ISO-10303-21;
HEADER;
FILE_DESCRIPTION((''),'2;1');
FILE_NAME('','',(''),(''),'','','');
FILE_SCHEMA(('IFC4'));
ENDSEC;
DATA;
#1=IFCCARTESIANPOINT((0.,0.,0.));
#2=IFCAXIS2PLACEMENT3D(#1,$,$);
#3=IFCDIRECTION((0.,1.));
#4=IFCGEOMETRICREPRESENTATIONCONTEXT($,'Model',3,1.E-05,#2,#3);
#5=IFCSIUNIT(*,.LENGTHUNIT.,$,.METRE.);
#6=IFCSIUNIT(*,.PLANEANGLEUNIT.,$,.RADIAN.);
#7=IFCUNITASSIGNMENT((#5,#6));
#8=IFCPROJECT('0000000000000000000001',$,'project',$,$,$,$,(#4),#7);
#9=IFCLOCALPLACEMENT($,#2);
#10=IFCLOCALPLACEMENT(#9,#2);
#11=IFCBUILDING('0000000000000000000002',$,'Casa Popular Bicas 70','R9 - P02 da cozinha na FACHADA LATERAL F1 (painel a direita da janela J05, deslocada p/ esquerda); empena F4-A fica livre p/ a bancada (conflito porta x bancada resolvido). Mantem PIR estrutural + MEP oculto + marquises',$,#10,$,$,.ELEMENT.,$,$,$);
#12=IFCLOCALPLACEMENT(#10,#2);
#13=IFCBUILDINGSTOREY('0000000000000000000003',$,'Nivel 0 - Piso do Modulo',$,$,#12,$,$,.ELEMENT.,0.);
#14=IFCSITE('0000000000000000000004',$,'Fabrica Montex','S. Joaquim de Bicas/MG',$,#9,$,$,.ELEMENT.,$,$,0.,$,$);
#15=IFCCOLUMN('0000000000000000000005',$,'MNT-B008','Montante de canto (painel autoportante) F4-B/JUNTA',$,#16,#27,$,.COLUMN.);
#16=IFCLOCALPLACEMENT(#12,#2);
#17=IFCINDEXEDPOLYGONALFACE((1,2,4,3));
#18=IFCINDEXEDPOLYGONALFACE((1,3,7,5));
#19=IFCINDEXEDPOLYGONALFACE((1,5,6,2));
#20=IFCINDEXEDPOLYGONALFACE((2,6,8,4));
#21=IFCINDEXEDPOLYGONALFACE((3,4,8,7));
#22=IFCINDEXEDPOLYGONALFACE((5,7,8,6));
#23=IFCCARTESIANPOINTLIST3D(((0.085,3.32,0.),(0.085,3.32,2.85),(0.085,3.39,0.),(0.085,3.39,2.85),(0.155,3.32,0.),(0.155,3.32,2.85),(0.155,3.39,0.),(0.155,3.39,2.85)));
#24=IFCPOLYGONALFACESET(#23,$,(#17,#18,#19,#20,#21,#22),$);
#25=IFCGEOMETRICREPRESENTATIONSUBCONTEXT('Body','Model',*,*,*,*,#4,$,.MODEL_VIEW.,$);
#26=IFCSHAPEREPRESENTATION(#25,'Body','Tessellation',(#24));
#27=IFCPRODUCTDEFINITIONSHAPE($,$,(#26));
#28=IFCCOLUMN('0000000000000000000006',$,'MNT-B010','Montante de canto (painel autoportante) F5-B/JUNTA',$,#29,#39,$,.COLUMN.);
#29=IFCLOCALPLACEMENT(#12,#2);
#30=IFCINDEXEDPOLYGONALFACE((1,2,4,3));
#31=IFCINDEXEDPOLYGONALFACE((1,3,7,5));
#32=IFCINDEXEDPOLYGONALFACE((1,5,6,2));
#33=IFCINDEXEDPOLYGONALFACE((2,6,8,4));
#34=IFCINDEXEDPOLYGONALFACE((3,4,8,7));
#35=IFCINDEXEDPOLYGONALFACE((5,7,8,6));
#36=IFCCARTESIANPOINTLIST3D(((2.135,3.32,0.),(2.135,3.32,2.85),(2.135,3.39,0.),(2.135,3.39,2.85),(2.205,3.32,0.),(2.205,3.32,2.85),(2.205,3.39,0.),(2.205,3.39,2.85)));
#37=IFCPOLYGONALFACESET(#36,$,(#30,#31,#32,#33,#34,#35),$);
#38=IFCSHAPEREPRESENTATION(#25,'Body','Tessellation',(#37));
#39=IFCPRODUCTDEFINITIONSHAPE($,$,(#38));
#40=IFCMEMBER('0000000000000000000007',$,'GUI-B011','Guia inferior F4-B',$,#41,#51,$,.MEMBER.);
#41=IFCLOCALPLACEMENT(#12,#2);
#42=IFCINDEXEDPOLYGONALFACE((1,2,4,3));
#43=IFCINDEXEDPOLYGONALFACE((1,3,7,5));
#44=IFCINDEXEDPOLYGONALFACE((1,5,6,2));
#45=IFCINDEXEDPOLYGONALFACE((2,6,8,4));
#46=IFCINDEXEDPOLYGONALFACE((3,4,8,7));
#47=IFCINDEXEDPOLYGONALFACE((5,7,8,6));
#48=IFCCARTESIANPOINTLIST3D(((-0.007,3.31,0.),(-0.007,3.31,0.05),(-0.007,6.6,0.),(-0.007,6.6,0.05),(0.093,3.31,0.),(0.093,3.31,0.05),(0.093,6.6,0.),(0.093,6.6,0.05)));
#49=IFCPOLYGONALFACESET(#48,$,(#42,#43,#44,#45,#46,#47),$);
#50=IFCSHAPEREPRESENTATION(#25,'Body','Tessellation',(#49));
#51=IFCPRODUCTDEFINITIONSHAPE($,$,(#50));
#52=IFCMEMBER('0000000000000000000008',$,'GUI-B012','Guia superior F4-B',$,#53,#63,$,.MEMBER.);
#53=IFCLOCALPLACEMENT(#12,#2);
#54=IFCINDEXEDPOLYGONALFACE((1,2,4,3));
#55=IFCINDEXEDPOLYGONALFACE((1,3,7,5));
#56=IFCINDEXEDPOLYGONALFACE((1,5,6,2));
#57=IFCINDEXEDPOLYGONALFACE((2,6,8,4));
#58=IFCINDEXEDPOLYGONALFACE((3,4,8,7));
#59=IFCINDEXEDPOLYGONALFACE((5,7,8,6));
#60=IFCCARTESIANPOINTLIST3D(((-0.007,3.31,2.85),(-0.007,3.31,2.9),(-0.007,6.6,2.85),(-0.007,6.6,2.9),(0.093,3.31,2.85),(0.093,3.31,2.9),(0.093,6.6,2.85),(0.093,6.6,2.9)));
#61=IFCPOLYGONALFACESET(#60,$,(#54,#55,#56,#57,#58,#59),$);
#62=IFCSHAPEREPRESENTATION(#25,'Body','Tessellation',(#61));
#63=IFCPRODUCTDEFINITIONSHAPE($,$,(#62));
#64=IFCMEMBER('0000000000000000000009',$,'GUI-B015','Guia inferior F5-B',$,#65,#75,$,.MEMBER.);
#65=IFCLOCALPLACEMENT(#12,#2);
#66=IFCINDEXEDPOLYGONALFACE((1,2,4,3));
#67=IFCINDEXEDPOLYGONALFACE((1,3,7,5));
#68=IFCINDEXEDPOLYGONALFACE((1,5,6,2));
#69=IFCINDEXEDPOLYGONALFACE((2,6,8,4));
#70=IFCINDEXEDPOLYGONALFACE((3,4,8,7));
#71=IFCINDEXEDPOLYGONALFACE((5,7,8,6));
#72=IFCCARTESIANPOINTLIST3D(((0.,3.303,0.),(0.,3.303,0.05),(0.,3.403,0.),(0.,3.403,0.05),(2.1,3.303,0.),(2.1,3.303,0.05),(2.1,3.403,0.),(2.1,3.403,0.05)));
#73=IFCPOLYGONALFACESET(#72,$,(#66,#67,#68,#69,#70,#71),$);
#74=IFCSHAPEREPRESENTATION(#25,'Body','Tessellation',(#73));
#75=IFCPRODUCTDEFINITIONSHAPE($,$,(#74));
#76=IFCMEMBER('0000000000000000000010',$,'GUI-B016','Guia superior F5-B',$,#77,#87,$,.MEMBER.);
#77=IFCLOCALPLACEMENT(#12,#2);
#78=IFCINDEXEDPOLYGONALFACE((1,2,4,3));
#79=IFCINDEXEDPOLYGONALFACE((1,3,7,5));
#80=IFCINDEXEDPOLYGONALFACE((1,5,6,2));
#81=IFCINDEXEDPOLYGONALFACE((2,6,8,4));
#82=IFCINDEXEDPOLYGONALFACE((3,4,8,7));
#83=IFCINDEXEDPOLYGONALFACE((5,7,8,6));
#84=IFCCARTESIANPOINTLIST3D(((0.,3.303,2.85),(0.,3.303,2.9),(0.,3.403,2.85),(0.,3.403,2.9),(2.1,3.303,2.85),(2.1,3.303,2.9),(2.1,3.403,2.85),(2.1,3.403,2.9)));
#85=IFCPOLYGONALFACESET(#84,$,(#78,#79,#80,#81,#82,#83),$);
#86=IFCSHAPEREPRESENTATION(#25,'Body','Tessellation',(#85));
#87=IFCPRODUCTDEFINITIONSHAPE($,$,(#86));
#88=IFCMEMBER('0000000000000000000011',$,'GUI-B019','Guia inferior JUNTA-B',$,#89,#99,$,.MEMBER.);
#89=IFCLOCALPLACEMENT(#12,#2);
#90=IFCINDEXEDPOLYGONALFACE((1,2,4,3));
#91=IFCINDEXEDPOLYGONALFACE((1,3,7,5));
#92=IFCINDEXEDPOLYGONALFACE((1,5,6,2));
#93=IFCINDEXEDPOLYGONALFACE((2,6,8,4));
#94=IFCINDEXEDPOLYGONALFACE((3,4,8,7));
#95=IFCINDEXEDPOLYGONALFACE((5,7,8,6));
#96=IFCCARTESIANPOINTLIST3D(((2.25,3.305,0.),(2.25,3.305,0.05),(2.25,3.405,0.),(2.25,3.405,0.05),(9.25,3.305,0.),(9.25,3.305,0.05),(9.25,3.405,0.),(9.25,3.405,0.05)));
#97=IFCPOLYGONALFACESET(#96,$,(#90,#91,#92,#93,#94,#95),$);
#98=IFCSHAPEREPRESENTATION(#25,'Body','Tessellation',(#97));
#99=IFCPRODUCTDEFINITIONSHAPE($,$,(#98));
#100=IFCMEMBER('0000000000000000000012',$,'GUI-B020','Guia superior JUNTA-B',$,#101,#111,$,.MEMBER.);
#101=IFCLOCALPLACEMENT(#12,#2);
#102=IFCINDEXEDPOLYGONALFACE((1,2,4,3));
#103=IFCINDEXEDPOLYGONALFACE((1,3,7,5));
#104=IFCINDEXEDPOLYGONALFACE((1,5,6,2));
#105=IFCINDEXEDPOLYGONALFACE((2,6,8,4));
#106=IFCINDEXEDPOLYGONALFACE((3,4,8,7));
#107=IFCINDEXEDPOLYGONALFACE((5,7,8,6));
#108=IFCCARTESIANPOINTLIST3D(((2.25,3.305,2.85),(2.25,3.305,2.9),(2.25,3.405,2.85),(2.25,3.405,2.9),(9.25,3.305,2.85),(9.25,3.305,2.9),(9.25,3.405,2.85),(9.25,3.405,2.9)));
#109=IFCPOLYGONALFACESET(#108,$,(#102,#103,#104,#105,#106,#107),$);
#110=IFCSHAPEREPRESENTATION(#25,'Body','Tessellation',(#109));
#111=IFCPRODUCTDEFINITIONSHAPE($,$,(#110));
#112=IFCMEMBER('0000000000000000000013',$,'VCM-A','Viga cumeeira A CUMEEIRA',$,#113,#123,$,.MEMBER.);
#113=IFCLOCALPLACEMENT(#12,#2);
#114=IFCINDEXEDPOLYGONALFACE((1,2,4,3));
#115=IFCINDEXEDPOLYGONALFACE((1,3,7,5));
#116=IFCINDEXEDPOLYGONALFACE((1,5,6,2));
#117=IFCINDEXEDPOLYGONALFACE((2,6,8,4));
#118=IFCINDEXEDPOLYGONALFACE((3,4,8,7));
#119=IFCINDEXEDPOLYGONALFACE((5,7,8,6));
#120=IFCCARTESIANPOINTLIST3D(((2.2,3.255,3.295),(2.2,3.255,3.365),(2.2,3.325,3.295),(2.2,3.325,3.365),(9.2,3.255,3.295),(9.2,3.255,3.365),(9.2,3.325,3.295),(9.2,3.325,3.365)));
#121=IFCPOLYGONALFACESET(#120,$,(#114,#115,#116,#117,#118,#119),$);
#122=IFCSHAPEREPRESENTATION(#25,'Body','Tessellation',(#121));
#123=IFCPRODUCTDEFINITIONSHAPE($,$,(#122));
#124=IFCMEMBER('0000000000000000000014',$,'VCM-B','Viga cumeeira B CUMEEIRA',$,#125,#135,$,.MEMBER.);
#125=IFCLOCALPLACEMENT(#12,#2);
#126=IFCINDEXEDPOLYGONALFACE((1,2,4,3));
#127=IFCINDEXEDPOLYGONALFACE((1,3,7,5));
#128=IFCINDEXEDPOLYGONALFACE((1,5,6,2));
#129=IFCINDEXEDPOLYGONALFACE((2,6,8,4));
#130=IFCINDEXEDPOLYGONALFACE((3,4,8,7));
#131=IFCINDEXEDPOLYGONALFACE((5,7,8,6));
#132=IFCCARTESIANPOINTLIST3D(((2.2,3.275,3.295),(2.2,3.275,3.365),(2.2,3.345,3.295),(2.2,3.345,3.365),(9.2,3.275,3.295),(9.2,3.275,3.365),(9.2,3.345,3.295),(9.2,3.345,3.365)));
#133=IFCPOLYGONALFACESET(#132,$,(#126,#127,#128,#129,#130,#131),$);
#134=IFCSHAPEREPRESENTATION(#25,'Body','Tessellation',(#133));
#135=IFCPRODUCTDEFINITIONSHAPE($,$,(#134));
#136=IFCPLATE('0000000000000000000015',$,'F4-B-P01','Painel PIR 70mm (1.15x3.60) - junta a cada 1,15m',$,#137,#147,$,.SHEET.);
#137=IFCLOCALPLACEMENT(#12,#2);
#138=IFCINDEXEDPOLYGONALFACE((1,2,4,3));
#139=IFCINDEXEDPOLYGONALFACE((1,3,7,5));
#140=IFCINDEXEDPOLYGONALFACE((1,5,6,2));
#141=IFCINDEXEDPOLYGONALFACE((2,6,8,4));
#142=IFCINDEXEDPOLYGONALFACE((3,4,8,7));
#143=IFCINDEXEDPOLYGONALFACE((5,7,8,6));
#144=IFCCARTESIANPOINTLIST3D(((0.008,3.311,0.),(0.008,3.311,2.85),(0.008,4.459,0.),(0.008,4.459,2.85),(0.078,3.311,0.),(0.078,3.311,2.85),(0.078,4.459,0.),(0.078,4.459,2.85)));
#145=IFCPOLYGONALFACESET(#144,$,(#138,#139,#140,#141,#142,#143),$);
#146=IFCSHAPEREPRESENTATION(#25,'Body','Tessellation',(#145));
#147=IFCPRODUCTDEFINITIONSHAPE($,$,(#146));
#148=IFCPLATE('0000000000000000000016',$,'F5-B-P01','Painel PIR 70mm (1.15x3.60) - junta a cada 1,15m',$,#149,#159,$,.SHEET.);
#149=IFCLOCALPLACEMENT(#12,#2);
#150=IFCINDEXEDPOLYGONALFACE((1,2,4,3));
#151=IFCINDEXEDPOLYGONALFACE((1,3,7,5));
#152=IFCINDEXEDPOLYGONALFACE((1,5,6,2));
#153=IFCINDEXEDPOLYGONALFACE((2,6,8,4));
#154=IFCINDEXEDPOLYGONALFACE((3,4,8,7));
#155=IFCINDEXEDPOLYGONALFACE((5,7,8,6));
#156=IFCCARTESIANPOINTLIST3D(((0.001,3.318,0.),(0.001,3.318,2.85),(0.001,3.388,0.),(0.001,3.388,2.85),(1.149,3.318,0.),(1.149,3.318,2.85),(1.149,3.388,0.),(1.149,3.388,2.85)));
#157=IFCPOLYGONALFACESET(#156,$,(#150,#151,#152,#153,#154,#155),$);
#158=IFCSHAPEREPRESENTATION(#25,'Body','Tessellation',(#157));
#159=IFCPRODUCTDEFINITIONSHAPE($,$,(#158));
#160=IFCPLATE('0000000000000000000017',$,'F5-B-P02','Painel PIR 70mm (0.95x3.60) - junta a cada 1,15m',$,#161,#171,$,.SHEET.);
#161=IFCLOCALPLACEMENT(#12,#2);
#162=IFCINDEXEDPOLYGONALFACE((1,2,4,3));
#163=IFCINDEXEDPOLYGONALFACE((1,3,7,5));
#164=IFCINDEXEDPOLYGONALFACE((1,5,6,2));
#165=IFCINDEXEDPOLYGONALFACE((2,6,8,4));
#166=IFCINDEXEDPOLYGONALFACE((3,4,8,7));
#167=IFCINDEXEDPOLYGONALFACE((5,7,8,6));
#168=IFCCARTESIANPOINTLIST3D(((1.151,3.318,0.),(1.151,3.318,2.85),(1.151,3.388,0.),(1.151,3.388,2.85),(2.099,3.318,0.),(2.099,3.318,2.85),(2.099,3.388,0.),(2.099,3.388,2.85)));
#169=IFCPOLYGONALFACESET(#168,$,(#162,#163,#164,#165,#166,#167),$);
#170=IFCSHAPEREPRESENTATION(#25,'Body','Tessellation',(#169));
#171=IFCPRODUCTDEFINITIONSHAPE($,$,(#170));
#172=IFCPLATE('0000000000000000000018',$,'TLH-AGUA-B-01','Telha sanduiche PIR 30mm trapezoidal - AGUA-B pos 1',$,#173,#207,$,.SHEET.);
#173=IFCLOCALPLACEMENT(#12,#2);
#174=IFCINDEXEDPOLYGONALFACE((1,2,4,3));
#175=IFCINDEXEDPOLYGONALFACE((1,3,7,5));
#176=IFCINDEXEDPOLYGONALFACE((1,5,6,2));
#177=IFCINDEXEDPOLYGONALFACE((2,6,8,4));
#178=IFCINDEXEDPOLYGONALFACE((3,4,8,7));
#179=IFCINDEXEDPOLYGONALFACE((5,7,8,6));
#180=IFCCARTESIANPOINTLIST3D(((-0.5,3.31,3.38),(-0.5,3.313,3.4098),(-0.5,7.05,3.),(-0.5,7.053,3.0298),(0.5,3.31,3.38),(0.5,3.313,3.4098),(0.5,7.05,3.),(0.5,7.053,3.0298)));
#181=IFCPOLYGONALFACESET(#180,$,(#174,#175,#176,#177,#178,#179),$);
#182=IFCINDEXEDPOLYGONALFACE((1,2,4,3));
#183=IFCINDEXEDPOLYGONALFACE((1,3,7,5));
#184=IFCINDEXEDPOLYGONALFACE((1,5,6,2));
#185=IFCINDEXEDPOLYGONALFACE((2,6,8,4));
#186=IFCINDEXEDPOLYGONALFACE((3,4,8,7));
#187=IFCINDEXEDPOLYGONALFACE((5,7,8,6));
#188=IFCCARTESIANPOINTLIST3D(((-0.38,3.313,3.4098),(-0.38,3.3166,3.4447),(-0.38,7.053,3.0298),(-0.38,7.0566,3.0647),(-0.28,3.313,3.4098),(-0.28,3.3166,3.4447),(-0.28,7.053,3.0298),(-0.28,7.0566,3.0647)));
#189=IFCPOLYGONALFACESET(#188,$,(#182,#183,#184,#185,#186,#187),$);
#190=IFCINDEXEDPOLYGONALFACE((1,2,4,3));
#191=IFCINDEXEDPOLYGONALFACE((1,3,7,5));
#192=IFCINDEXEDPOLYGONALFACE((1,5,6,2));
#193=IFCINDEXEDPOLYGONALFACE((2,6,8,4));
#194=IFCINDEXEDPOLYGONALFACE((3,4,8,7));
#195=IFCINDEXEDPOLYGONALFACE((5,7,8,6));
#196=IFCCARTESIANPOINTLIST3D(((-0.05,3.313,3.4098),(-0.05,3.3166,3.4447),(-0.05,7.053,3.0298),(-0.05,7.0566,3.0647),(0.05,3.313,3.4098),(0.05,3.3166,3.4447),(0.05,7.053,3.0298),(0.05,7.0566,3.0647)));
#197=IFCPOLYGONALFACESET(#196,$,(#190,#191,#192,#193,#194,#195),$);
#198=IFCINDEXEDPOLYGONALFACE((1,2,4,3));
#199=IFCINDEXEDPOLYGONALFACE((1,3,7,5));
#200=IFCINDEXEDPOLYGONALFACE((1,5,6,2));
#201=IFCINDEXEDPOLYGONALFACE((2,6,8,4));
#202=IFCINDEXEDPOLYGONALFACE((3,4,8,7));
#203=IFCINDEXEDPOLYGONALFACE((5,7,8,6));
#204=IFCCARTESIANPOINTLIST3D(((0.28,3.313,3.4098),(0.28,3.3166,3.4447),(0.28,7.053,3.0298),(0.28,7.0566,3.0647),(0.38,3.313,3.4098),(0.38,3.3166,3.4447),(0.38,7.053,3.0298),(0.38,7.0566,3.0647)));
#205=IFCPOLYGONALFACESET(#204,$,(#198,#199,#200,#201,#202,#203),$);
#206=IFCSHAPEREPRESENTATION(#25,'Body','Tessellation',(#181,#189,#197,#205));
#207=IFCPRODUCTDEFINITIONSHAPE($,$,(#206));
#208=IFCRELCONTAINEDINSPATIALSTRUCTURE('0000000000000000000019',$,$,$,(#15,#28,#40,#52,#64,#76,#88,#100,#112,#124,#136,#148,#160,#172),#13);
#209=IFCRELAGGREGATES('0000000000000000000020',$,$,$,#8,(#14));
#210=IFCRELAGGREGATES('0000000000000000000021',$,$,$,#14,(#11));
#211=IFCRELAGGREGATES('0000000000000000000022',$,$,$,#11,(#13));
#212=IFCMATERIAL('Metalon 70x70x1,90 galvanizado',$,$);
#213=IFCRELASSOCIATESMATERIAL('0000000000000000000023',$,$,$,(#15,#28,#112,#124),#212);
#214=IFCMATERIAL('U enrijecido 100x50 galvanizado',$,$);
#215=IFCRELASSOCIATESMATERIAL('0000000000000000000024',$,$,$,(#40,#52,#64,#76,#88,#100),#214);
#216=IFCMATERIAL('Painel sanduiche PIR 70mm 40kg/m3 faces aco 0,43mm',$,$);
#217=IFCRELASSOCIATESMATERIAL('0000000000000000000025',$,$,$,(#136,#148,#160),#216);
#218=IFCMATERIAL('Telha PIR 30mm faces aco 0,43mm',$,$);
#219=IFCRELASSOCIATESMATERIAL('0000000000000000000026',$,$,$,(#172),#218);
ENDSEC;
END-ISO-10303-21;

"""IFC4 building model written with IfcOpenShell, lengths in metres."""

from ifc_helpers import new_model, si_unit, direction, frame, frame_2d, origin, origin_2d, place, context, subcontext, project, spatial, rectangle, extrude, material, element, save


model = new_model("IFC4")

# Units and contexts
model_context = context("Model", 3, precision=1e-05, world=origin(), true_north=direction((0.0, 1.0)))
body_context = subcontext(model_context, "Body", "Model", "MODEL_VIEW")
ifc_project = project(units=[si_unit("LENGTHUNIT", "METRE"), si_unit("PLANEANGLEUNIT", "RADIAN")], contexts=[model_context])

# Site, building, storey
site_placement = place(None, origin())
site = spatial("IfcSite", under=ifc_project, at=site_placement, Name="Fabrica Montex", Description="S. Joaquim de Bicas/MG", CompositionType="ELEMENT", RefElevation=0.0)
building_placement = place(site_placement, origin())
building = spatial("IfcBuilding", under=site, at=building_placement, Name="Casa Popular Bicas 70", Description="R9 - P02 da cozinha na FACHADA LATERAL F1 (painel a direita da janela J05, deslocada p/ esquerda); empena F4-A fica livre p/ a bancada (conflito porta x bancada resolvido). Mantem PIR estrutural + MEP oculto + marquises", CompositionType="ELEMENT")
storey_placement = place(building_placement, origin())
storey = spatial("IfcBuildingStorey", under=building, at=storey_placement, Name="Nivel 0 - Piso do Modulo", CompositionType="ELEMENT", Elevation=0.0)

# Columns
ifc_material_1 = material(Name="Metalon 70x70x1,90 galvanizado")
for number, where, name, description in (
    (1, (0.12, 3.355, 0.0), "MNT-B008", "Montante de canto (painel autoportante) F4-B/JUNTA"),
    (2, (2.17, 3.355, 0.0), "MNT-B010", "Montante de canto (painel autoportante) F5-B/JUNTA"),
):
    element("IfcColumn", number, at=place(storey_placement, frame(where)), inside=storey, material=ifc_material_1, Name=name, Description=description, PredefinedType="COLUMN", context=body_context, shape_type="SweptSolid", body=[
        extrude(rectangle(XDim=0.07, YDim=0.07, at=origin_2d()), origin(), (0.0, 0.0, 1.0), 2.85),
    ])

# Members
ifc_material_2 = material(Name="U enrijecido 100x50 galvanizado")
for number, where, z_axis, x_axis, name, description in (
    (3, (0.043, 3.31, 0.025), (0.0, 1.0, 0.0), (0.0, 0.0, 1.0), "GUI-B011", "Guia inferior F4-B"),
    (4, (0.043, 3.31, 2.875), (0.0, 1.0, 0.0), (0.0, 0.0, 1.0), "GUI-B012", "Guia superior F4-B"),
):
    element("IfcMember", number, at=place(storey_placement, frame(where, z_axis=z_axis, x_axis=x_axis)), inside=storey, material=ifc_material_2, Name=name, Description=description, PredefinedType="MEMBER", context=body_context, shape_type="SweptSolid", body=[
        extrude(rectangle(XDim=0.05, YDim=0.1, at=origin_2d()), origin(), (0.0, 0.0, 1.0), 3.29),
    ])
for number, where, z_axis, x_axis, name, description in (
    (5, (0.0, 3.353, 0.025), (1.0, 0.0, 0.0), (0.0, 0.0, 1.0), "GUI-B015", "Guia inferior F5-B"),
    (6, (0.0, 3.353, 2.875), (1.0, 0.0, 0.0), (0.0, 0.0, 1.0), "GUI-B016", "Guia superior F5-B"),
):
    element("IfcMember", number, at=place(storey_placement, frame(where, z_axis=z_axis, x_axis=x_axis)), inside=storey, material=ifc_material_2, Name=name, Description=description, PredefinedType="MEMBER", context=body_context, shape_type="SweptSolid", body=[
        extrude(rectangle(XDim=0.05, YDim=0.1, at=origin_2d()), origin(), (0.0, 0.0, 1.0), 2.1),
    ])
for number, where, z_axis, x_axis, name, description in (
    (7, (2.25, 3.355, 0.025), (1.0, 0.0, 0.0), (0.0, 0.0, 1.0), "GUI-B019", "Guia inferior JUNTA-B"),
    (8, (2.25, 3.355, 2.875), (1.0, 0.0, 0.0), (0.0, 0.0, 1.0), "GUI-B020", "Guia superior JUNTA-B"),
):
    element("IfcMember", number, at=place(storey_placement, frame(where, z_axis=z_axis, x_axis=x_axis)), inside=storey, material=ifc_material_2, Name=name, Description=description, PredefinedType="MEMBER", context=body_context, shape_type="SweptSolid", body=[
        extrude(rectangle(XDim=0.05, YDim=0.1, at=origin_2d()), origin(), (0.0, 0.0, 1.0), 7.0),
    ])
for number, where, z_axis, x_axis, name, description in (
    (9, (2.2, 3.29, 3.33), (1.0, 0.0, 0.0), (0.0, 0.0, 1.0), "VCM-A", "Viga cumeeira A CUMEEIRA"),
    (10, (2.2, 3.31, 3.33), (1.0, 0.0, 0.0), (0.0, 0.0, 1.0), "VCM-B", "Viga cumeeira B CUMEEIRA"),
):
    element("IfcMember", number, at=place(storey_placement, frame(where, z_axis=z_axis, x_axis=x_axis)), inside=storey, material=ifc_material_1, Name=name, Description=description, PredefinedType="MEMBER", context=body_context, shape_type="SweptSolid", body=[
        extrude(rectangle(XDim=0.07, YDim=0.07, at=origin_2d()), origin(), (0.0, 0.0, 1.0), 7.0),
    ])

# Plates
ifc_material_3 = material(Name="Painel sanduiche PIR 70mm 40kg/m3 faces aco 0,43mm")
for number, where, x_axis, name in (
    (11, (0.043, 3.311, 0.0), (0.0, 1.0, 0.0), "F4-B-P01"),
    (12, (0.001, 3.353, 0.0), (1.0, 0.0, 0.0), "F5-B-P01"),
):
    element("IfcPlate", number, at=place(storey_placement, frame(where, x_axis=x_axis)), inside=storey, material=ifc_material_3, Name=name, Description="Painel PIR 70mm (1.15x3.60) - junta a cada 1,15m", PredefinedType="SHEET", context=body_context, shape_type="SweptSolid", body=[
        extrude(rectangle(XDim=1.148, YDim=0.07, at=frame_2d((0.574, 0.0))), origin(), (0.0, 0.0, 1.0), 2.85),
    ])
plate_1_placement = place(storey_placement, frame((1.151, 3.353, 0.0), x_axis=(1.0, 0.0, 0.0)))
element("IfcPlate", 13, at=plate_1_placement, inside=storey, material=ifc_material_3, Name="F5-B-P02", Description="Painel PIR 70mm (0.95x3.60) - junta a cada 1,15m", PredefinedType="SHEET", context=body_context, shape_type="SweptSolid", body=[
    extrude(rectangle(XDim=0.948, YDim=0.07, at=frame_2d((0.474, 0.0))), origin(), (0.0, 0.0, 1.0), 2.85),
])

# Plate
ifc_material_4 = material(Name="Telha PIR 30mm faces aco 0,43mm")
for number, where, z_axis, x_axis, name in (
    (14, (-0.5, 3.31, 3.38), (0.0, 0.101084, 0.994878), (1.0, 0.0, 0.0), "TLH-AGUA-B-01"),
):
    element("IfcPlate", number, at=place(storey_placement, frame(where, z_axis=z_axis, x_axis=x_axis)), inside=storey, material=ifc_material_4, Name=name, Description="Telha sanduiche PIR 30mm trapezoidal - AGUA-B pos 1", PredefinedType="SHEET", context=body_context, shape_type="SweptSolid", body=[
        extrude(rectangle(XDim=1.0, YDim=3.7593, at=frame_2d((0.5, 1.8796))), origin(), (0.0, 0.0, 1.0), 0.03),
        extrude(rectangle(XDim=0.1, YDim=3.7593, at=frame_2d((0.17, 1.8796))), frame((0.0, 0.0, 0.03)), (0.0, 0.0, 1.0), 0.035),
        extrude(rectangle(XDim=0.1, YDim=3.7593, at=frame_2d((0.5, 1.8796))), frame((0.0, 0.0, 0.03)), (0.0, 0.0, 1.0), 0.035),
        extrude(rectangle(XDim=0.1, YDim=3.7593, at=frame_2d((0.83, 1.8796))), frame((0.0, 0.0, 0.03)), (0.0, 0.0, 1.0), 0.035),
    ])

save(model, "model.ifc")
